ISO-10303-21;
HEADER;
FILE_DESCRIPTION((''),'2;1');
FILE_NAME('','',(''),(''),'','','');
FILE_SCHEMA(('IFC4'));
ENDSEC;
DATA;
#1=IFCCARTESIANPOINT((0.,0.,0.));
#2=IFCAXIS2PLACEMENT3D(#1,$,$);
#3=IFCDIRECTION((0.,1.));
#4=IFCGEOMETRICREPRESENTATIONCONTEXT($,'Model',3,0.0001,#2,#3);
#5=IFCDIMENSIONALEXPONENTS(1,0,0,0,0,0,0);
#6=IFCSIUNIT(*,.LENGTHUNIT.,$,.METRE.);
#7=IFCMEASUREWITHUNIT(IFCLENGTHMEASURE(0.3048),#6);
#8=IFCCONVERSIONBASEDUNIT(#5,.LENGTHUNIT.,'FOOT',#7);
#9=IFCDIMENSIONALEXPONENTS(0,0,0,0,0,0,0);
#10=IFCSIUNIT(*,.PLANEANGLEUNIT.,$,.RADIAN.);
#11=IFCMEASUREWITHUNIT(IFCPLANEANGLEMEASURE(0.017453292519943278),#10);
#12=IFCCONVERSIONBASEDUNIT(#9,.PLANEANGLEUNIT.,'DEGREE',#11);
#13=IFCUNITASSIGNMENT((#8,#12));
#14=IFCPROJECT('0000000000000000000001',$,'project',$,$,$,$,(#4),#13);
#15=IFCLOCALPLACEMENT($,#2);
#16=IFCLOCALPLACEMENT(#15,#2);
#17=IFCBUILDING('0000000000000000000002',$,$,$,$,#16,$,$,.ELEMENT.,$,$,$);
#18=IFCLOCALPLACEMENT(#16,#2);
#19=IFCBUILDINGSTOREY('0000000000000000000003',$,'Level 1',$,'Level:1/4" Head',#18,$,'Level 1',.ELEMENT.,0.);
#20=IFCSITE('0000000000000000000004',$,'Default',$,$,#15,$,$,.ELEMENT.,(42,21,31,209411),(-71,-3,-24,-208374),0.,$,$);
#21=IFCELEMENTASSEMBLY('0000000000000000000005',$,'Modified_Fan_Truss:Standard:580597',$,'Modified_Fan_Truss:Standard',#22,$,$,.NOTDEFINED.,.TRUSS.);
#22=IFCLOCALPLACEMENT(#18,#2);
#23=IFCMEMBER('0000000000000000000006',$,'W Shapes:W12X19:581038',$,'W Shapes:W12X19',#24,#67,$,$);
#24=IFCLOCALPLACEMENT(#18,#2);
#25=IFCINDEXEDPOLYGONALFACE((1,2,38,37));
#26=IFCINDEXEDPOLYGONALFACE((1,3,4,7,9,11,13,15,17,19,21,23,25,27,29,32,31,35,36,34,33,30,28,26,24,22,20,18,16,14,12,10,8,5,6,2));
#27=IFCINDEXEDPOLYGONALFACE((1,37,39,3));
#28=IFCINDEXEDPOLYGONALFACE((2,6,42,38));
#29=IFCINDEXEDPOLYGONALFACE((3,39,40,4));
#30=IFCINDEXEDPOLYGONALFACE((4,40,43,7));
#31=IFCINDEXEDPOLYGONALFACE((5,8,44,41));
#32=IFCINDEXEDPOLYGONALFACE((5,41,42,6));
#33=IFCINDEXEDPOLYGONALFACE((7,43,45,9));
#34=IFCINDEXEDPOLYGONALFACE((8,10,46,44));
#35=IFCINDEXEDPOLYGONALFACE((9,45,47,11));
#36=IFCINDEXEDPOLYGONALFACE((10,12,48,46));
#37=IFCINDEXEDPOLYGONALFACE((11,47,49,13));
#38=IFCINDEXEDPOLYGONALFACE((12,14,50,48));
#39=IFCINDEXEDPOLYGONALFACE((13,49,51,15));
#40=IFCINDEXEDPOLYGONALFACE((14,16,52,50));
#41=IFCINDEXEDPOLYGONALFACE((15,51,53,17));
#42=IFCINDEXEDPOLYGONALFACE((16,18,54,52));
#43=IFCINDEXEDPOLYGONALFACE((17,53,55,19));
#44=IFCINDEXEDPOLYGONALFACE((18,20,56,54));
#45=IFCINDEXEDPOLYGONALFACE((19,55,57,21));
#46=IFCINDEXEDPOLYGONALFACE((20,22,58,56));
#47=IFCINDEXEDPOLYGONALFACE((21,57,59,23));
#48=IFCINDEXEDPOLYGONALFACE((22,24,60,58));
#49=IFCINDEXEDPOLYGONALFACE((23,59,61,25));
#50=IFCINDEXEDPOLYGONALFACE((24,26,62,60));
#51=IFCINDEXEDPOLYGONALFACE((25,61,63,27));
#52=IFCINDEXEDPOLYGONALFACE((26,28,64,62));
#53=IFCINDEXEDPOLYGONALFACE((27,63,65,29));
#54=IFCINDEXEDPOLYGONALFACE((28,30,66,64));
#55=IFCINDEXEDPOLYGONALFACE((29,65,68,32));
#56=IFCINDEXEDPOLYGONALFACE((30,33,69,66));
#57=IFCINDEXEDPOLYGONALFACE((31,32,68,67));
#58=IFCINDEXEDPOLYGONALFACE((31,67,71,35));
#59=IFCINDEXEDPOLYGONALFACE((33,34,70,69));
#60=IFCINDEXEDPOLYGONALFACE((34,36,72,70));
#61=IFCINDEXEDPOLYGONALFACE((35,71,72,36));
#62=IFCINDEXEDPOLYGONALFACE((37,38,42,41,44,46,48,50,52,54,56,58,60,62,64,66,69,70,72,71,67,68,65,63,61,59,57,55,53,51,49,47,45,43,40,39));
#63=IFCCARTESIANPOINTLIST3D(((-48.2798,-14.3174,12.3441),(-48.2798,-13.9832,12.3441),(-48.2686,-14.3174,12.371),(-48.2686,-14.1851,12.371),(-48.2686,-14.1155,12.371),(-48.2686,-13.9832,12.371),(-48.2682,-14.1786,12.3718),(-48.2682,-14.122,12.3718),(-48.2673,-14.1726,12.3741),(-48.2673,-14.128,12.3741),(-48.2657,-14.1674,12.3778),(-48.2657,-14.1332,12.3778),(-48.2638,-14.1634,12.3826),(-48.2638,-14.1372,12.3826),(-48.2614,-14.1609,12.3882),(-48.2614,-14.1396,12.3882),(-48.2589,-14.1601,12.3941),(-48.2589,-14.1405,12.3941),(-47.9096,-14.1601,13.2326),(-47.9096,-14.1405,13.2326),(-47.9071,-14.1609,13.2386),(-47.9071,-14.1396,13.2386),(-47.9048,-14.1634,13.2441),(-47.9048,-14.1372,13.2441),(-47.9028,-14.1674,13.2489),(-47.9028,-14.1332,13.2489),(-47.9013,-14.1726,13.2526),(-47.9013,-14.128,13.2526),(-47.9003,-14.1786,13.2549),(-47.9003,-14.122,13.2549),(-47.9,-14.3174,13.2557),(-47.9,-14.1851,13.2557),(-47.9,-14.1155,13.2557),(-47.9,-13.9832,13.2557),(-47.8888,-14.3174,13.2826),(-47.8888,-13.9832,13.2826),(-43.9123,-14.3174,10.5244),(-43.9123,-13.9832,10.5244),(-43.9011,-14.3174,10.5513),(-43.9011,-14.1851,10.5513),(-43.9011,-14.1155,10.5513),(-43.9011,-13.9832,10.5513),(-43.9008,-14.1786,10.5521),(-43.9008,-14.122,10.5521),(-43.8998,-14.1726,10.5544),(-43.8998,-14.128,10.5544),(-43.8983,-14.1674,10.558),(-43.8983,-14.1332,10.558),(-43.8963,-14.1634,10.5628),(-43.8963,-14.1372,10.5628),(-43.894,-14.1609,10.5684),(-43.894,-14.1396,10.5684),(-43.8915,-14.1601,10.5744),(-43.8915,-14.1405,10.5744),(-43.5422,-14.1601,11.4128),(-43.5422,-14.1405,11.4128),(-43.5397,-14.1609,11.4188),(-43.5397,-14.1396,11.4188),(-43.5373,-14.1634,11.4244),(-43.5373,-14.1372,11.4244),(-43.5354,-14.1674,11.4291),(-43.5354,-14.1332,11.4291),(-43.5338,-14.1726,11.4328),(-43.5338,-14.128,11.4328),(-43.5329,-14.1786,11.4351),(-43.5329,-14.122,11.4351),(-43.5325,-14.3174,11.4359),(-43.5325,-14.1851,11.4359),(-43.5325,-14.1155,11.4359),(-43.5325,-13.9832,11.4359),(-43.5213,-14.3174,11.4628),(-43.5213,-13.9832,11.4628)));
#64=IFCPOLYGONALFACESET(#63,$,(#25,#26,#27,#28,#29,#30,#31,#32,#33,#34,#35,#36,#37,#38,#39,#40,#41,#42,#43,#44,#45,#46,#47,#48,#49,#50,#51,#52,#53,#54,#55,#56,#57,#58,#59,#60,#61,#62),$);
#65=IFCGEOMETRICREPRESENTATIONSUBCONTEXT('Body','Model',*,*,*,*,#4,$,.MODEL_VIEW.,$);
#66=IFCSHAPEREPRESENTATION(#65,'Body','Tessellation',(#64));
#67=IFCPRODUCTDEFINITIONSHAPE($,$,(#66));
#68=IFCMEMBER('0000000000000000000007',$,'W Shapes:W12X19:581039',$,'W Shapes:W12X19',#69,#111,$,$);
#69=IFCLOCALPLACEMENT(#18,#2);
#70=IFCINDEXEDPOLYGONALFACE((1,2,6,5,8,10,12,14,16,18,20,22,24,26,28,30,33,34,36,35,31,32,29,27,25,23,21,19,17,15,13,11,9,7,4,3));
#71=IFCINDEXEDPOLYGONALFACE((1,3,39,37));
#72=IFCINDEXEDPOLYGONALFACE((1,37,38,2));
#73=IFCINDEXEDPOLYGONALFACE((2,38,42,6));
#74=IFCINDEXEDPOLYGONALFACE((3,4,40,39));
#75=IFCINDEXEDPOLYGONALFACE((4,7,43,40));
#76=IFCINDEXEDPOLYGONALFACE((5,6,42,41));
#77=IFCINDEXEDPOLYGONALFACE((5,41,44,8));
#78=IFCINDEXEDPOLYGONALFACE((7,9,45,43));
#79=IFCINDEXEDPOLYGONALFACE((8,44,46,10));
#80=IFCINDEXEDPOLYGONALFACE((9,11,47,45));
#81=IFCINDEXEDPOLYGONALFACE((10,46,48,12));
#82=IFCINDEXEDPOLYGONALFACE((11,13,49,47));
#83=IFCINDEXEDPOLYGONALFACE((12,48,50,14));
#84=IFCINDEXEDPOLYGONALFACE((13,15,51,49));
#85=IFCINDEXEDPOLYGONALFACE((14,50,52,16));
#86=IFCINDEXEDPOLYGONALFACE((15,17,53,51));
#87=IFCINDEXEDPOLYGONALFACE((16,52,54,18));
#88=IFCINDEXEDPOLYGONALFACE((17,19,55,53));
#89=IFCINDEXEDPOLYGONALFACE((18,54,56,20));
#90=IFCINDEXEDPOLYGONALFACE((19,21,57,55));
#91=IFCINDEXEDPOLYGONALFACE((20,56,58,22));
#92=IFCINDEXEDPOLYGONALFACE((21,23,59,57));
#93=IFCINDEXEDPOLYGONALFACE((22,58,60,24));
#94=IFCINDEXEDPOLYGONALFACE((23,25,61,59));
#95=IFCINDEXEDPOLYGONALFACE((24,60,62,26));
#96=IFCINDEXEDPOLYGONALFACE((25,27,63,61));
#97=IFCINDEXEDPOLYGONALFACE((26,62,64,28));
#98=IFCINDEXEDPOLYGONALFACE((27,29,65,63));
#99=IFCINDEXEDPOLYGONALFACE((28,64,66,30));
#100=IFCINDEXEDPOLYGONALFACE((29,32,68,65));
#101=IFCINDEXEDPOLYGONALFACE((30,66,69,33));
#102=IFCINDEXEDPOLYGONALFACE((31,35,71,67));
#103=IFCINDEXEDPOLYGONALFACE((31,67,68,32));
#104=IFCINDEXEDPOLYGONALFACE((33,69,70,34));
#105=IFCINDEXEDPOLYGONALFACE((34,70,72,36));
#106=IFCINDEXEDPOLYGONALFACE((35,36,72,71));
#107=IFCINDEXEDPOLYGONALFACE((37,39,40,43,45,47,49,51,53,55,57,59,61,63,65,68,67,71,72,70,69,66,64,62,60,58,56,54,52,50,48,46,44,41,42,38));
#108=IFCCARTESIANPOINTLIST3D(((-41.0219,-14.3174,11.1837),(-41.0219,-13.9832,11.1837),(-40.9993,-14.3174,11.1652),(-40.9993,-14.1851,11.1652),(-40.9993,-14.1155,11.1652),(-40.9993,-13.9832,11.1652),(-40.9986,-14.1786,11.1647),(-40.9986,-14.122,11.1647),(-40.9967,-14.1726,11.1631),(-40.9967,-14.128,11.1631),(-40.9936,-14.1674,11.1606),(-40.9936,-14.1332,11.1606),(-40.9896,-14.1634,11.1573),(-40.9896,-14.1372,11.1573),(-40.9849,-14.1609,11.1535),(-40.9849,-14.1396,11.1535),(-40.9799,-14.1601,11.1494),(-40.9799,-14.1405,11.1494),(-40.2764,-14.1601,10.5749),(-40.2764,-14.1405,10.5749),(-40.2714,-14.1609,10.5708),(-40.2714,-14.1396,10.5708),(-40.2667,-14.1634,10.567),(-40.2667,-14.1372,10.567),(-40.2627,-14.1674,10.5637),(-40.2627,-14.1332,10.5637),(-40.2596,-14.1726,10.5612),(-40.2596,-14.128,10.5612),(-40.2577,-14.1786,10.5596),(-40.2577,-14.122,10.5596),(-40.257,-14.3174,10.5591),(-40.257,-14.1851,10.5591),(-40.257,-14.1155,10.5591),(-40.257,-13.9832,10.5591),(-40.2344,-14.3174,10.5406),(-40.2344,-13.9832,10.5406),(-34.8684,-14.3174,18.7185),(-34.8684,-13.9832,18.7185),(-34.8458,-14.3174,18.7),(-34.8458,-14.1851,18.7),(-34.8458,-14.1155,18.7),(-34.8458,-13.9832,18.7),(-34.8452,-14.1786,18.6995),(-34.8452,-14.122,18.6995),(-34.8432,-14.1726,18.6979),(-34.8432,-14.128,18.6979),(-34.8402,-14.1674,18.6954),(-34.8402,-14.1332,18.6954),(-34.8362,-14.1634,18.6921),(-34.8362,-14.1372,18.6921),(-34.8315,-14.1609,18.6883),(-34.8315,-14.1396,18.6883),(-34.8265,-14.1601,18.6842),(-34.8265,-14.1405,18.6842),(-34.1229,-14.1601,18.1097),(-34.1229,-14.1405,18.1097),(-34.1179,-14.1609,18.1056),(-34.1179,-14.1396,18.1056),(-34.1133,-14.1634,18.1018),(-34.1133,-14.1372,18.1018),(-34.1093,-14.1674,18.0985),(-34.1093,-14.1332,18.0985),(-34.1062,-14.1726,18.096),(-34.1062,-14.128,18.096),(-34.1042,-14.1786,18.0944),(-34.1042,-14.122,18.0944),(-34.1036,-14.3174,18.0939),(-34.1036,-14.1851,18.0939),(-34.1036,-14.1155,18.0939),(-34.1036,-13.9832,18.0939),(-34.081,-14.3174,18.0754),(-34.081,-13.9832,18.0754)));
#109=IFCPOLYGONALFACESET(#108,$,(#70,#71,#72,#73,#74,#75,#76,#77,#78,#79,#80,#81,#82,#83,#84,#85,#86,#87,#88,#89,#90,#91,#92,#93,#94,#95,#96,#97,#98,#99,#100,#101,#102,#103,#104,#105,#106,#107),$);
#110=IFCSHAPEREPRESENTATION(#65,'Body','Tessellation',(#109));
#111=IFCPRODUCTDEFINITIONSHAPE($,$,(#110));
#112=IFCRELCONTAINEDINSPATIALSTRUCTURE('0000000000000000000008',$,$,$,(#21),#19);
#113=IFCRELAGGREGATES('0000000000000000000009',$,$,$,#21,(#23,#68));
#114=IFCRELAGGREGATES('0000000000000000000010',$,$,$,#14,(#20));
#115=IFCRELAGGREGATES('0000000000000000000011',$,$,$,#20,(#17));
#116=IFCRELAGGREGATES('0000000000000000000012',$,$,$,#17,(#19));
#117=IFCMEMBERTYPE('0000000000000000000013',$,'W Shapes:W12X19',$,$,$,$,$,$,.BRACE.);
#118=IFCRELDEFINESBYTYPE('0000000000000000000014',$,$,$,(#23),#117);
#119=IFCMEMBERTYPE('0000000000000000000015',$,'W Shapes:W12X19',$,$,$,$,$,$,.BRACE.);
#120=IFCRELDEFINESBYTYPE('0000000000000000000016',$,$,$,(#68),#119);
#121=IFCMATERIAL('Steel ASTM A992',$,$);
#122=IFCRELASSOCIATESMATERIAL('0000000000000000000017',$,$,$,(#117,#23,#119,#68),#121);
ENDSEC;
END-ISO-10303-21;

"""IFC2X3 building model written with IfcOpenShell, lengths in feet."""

from ifc_helpers import new_model, entity, si_unit, converted_unit, direction, frame, frame_2d, origin, place, context, subcontext, project, spatial, polyline, circle_curve, parameter, trimmed, segment, composite_curve, outline, extrude, source, transform, mapped, material, type_object, type_shapes, element, aggregate, save


model = new_model("IFC2X3")

# Units and contexts
model_context = context("Model", 3, precision=0.0001, world=origin(), true_north=direction((0.0, 1.0)))
body_context = subcontext(model_context, "Body", "Model", "MODEL_VIEW")
ifc_project = project(units=[converted_unit("LENGTHUNIT", "FOOT", entity("IfcLengthMeasure", 0.3048), si_unit("LENGTHUNIT", "METRE"), dimensions=[1, 0, 0, 0, 0, 0, 0]), converted_unit("PLANEANGLEUNIT", "DEGREE", entity("IfcPlaneAngleMeasure", 0.017453292519943278), si_unit("PLANEANGLEUNIT", "RADIAN"), dimensions=[0, 0, 0, 0, 0, 0, 0])], contexts=[model_context])

# Site, building, storey
site_placement = place(None, origin())
site = spatial("IfcSite", under=ifc_project, at=site_placement, Name="Default", CompositionType="ELEMENT", RefLatitude=(42, 21, 31, 209411), RefLongitude=(-71, -3, -24, -208374), RefElevation=0.0)
building_placement = place(site_placement, origin())
building = spatial("IfcBuilding", under=site, at=building_placement, CompositionType="ELEMENT")
storey_placement = place(building_placement, origin())
storey = spatial("IfcBuildingStorey", under=building, at=storey_placement, Name="Level 1", ObjectType="Level:1/4\" Head", LongName="Level 1", CompositionType="ELEMENT", Elevation=0.0)

# Element assembly, members
assembly_placement = place(storey_placement, origin())
assembly = element("IfcElementAssembly", 1, at=assembly_placement, inside=storey, Name="Modified_Fan_Truss:Standard:580597", ObjectType="Modified_Fan_Truss:Standard", AssemblyPlace="NOTDEFINED", PredefinedType="TRUSS")
ifc_material = material(Name="Steel ASTM A992")
member_type_1 = type_object("IfcMemberType", Name="W Shapes:W12X19", PredefinedType="BRACE", material=ifc_material)
shared_shape_1 = source(origin(), body_context, "Body", "SweptSolid", [
    extrude(outline(composite_curve([segment(polyline([(-0.1671, -0.4792), (-0.1671, -0.5083)]), True, "CONTINUOUS"), segment(polyline([(-0.1671, -0.5083), (0.1671, -0.5083)]), True, "CONTINUOUS"), segment(polyline([(0.1671, -0.5083), (0.1671, -0.4792)]), True, "CONTINUOUS"), segment(polyline([(0.1671, -0.4792), (0.0348, -0.4792)]), True, "CONTINUOUS"), segment(trimmed(circle_curve(frame_2d((0.0348, -0.4542), x_axis=(1.0, 0.0)), 0.025), [parameter(180.0)], [parameter(270.0)], True, "PARAMETER"), False, "CONTINUOUS"), segment(polyline([(0.0098, -0.4542), (0.0098, 0.4542)]), True, "CONTINUOUS"), segment(trimmed(circle_curve(frame_2d((0.0348, 0.4542), x_axis=(1.0, 0.0)), 0.025), [parameter(90.0)], [parameter(180.0)], True, "PARAMETER"), False, "CONTINUOUS"), segment(polyline([(0.0348, 0.4792), (0.1671, 0.4792)]), True, "CONTINUOUS"), segment(polyline([(0.1671, 0.4792), (0.1671, 0.5083)]), True, "CONTINUOUS"), segment(polyline([(0.1671, 0.5083), (-0.1671, 0.5083)]), True, "CONTINUOUS"), segment(polyline([(-0.1671, 0.5083), (-0.1671, 0.4792)]), True, "CONTINUOUS"), segment(polyline([(-0.1671, 0.4792), (-0.0348, 0.4792)]), True, "CONTINUOUS"), segment(trimmed(circle_curve(frame_2d((-0.0348, 0.4542), x_axis=(1.0, 0.0)), 0.025), [parameter(360.0)], [parameter(90.0)], True, "PARAMETER"), False, "CONTINUOUS"), segment(polyline([(-0.0098, 0.4542), (-0.0098, -0.4542)]), True, "CONTINUOUS"), segment(trimmed(circle_curve(frame_2d((-0.0348, -0.4542), x_axis=(1.0, 0.0)), 0.025), [parameter(270.0)], [parameter(360.0)], True, "PARAMETER"), False, "CONTINUOUS"), segment(polyline([(-0.0348, -0.4792), (-0.1671, -0.4792)]), True, "CONTINUOUS")], self_intersect=False)), frame((-3.0265, 0.0, 0.0), z_axis=(-1.0, 0.0, 0.0), x_axis=(0.0, -1.0, 0.0)), (0.0, 0.0, -1.0), 4.7314),
])
type_shapes(member_type_1, [shared_shape_1])
member_1_placement = place(assembly_placement, frame((-45.2905, -14.1503, 11.6493), z_axis=(-0.384615, 0.0, -0.923077), x_axis=(0.923077, 0.0, -0.384615)))
member_1 = element("IfcMember", 2, at=member_1_placement, type_object=member_type_1, material=ifc_material, Name="W Shapes:W12X19:581038", ObjectType="W Shapes:W12X19", context=body_context, shape_type="MappedRepresentation", body=[
    mapped(shared_shape_1, transform((0.0, 0.0, 0.0), scale=1.0)),
])
member_type_2 = type_object("IfcMemberType", Name="W Shapes:W12X19", PredefinedType="BRACE", material=ifc_material)
shared_shape_2 = source(origin(), body_context, "Body", "SweptSolid", [
    extrude(outline(composite_curve([segment(polyline([(-0.1671, -0.4792), (-0.1671, -0.5083)]), True, "CONTINUOUS"), segment(polyline([(-0.1671, -0.5083), (0.1671, -0.5083)]), True, "CONTINUOUS"), segment(polyline([(0.1671, -0.5083), (0.1671, -0.4792)]), True, "CONTINUOUS"), segment(polyline([(0.1671, -0.4792), (0.0348, -0.4792)]), True, "CONTINUOUS"), segment(trimmed(circle_curve(frame_2d((0.0348, -0.4542), x_axis=(1.0, 0.0)), 0.025), [parameter(180.0)], [parameter(270.0)], True, "PARAMETER"), False, "CONTINUOUS"), segment(polyline([(0.0098, -0.4542), (0.0098, 0.4542)]), True, "CONTINUOUS"), segment(trimmed(circle_curve(frame_2d((0.0348, 0.4542), x_axis=(1.0, 0.0)), 0.025), [parameter(90.0)], [parameter(180.0)], True, "PARAMETER"), False, "CONTINUOUS"), segment(polyline([(0.0348, 0.4792), (0.1671, 0.4792)]), True, "CONTINUOUS"), segment(polyline([(0.1671, 0.4792), (0.1671, 0.5083)]), True, "CONTINUOUS"), segment(polyline([(0.1671, 0.5083), (-0.1671, 0.5083)]), True, "CONTINUOUS"), segment(polyline([(-0.1671, 0.5083), (-0.1671, 0.4792)]), True, "CONTINUOUS"), segment(polyline([(-0.1671, 0.4792), (-0.0348, 0.4792)]), True, "CONTINUOUS"), segment(trimmed(circle_curve(frame_2d((-0.0348, 0.4542), x_axis=(1.0, 0.0)), 0.025), [parameter(360.0)], [parameter(90.0)], True, "PARAMETER"), False, "CONTINUOUS"), segment(polyline([(-0.0098, 0.4542), (-0.0098, -0.4542)]), True, "CONTINUOUS"), segment(trimmed(circle_curve(frame_2d((-0.0348, -0.4542), x_axis=(1.0, 0.0)), 0.025), [parameter(270.0)], [parameter(360.0)], True, "PARAMETER"), False, "CONTINUOUS"), segment(polyline([(-0.0348, -0.4792), (-0.1671, -0.4792)]), True, "CONTINUOUS")], self_intersect=False)), frame((-5.3424, 0.0, 0.0), z_axis=(-1.0, 0.0, 0.0), x_axis=(0.0, -1.0, 0.0)), (0.0, 0.0, -1.0), 9.7282),
])
type_shapes(member_type_2, [shared_shape_2])
member_2_placement = place(assembly_placement, frame((-37.2489, -14.1503, 15.0), z_axis=(0.774532, 0.0, -0.632535), x_axis=(0.632535, 0.0, 0.774532)))
member_2 = element("IfcMember", 3, at=member_2_placement, type_object=member_type_2, material=ifc_material, Name="W Shapes:W12X19:581039", ObjectType="W Shapes:W12X19", context=body_context, shape_type="MappedRepresentation", body=[
    mapped(shared_shape_2, transform((0.0, 0.0, 0.0), scale=1.0)),
])
aggregate(assembly, [member_1, member_2])

save(model, "model.ifc")
